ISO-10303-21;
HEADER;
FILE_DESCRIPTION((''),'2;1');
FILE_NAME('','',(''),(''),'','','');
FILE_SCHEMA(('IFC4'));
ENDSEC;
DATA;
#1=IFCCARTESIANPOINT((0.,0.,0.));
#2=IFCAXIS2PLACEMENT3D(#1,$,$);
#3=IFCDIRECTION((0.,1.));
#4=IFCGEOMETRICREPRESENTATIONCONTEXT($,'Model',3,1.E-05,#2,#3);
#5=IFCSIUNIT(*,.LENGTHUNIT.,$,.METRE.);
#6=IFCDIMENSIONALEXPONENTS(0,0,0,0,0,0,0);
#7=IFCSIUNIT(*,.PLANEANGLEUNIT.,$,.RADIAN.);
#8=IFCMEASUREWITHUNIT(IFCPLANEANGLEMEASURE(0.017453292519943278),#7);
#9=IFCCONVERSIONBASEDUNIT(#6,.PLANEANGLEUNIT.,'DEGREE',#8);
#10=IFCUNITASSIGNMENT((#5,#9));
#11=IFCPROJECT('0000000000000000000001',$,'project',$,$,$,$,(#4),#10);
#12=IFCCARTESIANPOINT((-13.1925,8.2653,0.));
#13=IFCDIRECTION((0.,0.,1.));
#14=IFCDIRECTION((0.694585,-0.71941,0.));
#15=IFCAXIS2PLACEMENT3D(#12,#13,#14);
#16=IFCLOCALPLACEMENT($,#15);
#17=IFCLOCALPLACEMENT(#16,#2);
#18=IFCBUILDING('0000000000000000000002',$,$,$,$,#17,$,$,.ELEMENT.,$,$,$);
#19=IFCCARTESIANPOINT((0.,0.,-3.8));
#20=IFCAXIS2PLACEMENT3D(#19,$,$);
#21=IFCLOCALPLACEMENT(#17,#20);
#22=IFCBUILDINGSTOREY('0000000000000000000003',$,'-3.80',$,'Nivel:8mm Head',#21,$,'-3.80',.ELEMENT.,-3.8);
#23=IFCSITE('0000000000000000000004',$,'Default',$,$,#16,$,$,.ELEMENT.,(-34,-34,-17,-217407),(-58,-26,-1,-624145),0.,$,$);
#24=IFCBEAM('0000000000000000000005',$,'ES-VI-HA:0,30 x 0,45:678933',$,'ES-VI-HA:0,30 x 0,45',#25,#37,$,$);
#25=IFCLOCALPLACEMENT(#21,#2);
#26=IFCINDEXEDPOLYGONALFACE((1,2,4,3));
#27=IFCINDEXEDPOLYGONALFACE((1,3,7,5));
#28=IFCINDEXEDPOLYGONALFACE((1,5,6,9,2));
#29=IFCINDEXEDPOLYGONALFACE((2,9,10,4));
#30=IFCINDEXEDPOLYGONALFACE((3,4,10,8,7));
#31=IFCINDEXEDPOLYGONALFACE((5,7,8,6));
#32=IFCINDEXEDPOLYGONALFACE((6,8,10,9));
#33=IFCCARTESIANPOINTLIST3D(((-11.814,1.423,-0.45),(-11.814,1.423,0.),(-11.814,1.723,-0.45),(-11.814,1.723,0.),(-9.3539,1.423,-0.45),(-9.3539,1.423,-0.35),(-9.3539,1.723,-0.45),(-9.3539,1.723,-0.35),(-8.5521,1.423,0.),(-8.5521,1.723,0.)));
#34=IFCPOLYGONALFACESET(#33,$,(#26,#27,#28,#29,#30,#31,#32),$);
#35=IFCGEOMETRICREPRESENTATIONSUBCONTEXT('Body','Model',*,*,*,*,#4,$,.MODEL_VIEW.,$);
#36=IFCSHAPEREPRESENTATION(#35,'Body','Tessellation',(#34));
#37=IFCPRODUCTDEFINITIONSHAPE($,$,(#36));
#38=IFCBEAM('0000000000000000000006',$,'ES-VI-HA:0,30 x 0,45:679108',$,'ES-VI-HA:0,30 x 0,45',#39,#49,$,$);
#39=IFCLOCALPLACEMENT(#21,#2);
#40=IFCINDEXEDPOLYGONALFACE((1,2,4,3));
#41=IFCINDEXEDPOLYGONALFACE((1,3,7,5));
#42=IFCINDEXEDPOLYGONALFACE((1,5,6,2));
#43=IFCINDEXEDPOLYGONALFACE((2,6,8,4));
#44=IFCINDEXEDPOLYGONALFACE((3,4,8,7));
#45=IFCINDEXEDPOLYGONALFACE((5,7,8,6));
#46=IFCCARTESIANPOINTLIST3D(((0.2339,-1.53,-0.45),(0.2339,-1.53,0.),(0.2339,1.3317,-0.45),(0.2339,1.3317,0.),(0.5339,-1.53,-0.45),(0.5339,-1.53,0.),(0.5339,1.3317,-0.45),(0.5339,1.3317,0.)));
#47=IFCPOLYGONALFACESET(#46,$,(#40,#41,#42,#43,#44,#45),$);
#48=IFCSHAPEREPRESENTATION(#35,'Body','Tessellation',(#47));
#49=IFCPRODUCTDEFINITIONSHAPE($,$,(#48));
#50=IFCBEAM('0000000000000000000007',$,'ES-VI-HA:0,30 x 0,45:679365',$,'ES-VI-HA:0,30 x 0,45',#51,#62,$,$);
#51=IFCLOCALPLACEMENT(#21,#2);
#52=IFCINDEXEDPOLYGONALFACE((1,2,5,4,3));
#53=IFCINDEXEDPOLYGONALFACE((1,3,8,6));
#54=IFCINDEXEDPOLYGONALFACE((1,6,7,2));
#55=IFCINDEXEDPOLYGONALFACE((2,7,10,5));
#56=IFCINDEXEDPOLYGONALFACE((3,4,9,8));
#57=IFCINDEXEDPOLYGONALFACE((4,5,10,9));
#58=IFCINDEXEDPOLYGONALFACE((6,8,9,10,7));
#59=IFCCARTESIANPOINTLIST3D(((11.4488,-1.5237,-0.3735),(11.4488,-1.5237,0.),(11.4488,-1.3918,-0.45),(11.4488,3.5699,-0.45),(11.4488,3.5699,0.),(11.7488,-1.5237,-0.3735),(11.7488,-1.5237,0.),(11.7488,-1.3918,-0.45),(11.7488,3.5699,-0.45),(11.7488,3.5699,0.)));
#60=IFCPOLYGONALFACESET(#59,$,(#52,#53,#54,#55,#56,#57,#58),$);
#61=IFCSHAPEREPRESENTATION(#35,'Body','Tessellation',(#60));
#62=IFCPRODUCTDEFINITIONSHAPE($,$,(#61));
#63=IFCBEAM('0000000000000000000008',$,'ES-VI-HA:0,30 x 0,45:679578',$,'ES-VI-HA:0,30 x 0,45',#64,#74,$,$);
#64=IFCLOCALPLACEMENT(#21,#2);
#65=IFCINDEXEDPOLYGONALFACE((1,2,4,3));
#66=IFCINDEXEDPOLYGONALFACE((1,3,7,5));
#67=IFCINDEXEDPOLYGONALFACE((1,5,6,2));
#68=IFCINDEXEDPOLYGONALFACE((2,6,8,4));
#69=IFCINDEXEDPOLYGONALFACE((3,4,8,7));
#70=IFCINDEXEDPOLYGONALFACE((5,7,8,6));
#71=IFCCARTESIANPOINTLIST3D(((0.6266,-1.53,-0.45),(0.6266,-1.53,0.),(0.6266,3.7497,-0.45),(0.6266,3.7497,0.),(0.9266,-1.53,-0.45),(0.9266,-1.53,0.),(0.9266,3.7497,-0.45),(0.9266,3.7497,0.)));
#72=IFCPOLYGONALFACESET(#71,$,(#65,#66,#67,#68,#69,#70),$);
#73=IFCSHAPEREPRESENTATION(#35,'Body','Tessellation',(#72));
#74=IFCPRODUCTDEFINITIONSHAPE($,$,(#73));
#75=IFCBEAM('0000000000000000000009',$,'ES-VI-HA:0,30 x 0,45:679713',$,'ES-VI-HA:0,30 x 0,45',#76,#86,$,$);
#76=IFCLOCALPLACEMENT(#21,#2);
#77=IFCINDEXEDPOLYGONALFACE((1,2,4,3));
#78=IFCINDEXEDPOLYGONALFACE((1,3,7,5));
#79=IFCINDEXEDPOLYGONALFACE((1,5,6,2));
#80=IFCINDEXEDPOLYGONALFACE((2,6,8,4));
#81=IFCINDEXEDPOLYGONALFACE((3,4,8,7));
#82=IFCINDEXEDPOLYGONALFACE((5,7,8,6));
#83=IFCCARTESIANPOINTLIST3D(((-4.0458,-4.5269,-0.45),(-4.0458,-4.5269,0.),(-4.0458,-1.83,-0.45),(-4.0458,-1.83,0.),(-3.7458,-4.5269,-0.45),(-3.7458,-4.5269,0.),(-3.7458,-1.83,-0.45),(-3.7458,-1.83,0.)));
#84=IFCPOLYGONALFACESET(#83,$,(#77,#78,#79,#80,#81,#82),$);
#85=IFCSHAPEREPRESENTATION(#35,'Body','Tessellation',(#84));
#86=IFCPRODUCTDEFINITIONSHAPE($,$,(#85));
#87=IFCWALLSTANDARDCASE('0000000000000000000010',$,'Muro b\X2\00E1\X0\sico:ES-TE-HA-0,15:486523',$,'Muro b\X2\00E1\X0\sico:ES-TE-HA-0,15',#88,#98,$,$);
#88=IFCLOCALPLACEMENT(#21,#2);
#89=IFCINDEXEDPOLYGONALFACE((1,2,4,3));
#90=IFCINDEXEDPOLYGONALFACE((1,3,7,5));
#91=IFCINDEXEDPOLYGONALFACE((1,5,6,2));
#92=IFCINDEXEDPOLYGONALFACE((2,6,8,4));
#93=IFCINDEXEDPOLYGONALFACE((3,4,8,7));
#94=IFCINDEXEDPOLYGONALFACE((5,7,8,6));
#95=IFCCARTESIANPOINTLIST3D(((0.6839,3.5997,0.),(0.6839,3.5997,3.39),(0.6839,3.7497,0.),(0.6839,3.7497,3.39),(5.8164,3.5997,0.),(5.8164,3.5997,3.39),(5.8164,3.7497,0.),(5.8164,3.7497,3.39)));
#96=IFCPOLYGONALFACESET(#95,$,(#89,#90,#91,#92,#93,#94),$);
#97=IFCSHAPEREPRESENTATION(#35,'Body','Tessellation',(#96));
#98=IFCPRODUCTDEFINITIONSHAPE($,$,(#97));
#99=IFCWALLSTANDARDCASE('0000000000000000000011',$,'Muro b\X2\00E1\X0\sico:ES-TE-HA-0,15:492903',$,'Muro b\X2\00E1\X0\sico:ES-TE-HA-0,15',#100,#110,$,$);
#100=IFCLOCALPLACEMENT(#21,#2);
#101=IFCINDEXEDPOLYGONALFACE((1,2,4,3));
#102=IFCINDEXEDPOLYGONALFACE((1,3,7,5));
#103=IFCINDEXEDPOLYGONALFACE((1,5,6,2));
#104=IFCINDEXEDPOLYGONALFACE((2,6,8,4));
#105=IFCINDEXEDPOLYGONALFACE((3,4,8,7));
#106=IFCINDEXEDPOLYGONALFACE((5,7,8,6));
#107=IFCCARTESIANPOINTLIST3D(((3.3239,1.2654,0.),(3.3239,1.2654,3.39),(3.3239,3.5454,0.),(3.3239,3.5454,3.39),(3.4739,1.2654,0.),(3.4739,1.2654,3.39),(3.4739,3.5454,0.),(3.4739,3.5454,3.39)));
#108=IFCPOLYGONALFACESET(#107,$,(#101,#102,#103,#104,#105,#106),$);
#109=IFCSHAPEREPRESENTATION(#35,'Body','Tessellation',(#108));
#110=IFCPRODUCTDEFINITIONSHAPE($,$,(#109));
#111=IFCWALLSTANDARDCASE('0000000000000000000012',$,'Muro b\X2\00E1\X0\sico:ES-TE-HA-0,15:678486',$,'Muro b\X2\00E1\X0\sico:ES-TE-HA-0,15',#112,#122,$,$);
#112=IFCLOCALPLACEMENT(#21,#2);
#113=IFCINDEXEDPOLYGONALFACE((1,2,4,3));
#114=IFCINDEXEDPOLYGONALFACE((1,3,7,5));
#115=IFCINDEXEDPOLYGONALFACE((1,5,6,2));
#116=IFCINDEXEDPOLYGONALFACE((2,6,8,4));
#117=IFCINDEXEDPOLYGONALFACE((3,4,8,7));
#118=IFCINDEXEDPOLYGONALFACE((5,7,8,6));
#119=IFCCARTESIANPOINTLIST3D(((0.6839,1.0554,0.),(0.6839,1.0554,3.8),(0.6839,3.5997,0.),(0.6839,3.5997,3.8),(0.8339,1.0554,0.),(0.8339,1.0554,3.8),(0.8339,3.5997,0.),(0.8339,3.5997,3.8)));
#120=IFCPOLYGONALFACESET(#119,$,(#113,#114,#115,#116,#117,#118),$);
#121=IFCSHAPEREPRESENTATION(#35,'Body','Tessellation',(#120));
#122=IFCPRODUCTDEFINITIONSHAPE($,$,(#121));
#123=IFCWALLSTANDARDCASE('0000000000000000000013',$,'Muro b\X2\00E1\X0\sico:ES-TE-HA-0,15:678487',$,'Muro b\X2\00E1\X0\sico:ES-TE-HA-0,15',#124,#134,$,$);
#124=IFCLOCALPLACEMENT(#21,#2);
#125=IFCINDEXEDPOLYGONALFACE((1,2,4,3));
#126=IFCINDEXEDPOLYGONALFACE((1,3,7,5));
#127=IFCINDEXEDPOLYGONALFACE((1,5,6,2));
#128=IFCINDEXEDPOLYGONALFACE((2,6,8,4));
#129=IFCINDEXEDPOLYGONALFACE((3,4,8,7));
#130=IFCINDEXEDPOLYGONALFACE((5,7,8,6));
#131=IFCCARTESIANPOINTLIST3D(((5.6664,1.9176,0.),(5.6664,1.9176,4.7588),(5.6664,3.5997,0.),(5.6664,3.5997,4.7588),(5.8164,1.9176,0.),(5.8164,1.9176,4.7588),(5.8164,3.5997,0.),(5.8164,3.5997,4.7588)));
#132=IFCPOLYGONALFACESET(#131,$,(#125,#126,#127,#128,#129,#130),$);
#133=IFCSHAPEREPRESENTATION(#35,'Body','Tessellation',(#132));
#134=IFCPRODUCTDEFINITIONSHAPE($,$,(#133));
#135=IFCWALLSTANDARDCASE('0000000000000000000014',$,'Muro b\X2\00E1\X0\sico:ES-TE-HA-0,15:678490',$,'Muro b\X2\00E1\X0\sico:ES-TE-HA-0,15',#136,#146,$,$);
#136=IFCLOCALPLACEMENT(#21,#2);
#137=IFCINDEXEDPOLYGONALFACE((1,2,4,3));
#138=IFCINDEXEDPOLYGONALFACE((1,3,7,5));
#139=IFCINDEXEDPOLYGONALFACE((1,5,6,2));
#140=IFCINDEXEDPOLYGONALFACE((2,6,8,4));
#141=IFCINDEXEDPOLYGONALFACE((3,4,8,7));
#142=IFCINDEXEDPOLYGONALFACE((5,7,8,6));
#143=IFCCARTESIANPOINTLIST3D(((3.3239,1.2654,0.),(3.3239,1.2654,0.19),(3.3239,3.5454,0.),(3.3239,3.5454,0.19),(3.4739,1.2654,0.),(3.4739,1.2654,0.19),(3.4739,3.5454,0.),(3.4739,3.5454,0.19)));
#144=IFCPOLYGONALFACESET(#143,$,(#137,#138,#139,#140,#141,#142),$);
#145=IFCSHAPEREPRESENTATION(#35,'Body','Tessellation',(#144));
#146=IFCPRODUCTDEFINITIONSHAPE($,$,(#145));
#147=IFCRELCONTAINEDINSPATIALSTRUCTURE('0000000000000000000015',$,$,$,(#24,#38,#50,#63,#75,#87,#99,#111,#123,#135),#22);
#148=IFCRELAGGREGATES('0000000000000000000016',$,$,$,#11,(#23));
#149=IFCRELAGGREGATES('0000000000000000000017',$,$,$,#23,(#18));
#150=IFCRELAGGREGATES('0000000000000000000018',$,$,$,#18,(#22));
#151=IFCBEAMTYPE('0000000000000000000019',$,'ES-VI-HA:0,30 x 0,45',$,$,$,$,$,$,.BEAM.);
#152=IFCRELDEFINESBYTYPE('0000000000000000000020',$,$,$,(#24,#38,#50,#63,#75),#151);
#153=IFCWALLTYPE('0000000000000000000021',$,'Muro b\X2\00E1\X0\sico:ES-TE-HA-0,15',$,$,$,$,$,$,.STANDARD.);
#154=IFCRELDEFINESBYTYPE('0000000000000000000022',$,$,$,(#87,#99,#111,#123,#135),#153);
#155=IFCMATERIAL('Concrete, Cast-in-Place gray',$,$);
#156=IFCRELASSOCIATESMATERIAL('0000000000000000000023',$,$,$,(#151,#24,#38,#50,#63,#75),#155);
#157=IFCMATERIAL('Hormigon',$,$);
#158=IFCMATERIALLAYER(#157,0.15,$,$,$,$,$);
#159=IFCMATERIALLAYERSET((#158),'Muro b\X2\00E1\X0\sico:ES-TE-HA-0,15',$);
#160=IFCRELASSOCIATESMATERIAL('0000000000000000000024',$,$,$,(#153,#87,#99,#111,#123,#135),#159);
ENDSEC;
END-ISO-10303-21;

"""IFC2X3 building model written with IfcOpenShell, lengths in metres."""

from ifc_helpers import new_model, entity, si_unit, converted_unit, direction, frame, frame_2d, origin, origin_2d_with_axis, place, context, subcontext, project, spatial, polyline, rectangle, extrude, clip, halfspace, bounded_halfspace, material, layer, layer_set, layer_usage, type_object, element, save


model = new_model("IFC2X3")

# Units and contexts
model_context = context("Model", 3, precision=1e-05, world=origin(), true_north=direction((0.0, 1.0)))
body_context = subcontext(model_context, "Body", "Model", "MODEL_VIEW")
ifc_project = project(units=[si_unit("LENGTHUNIT", "METRE"), converted_unit("PLANEANGLEUNIT", "DEGREE", entity("IfcPlaneAngleMeasure", 0.017453292519943278), si_unit("PLANEANGLEUNIT", "RADIAN"), dimensions=[0, 0, 0, 0, 0, 0, 0])], contexts=[model_context])

# Site, building, storey
site_placement = place(None, frame((-13.1925, 8.2653, 0.0), z_axis=(0.0, 0.0, 1.0), x_axis=(0.694585, -0.71941, 0.0)))
site = spatial("IfcSite", under=ifc_project, at=site_placement, Name="Default", CompositionType="ELEMENT", RefLatitude=(-34, -34, -17, -217407), RefLongitude=(-58, -26, -1, -624145), RefElevation=0.0)
building_placement = place(site_placement, origin())
building = spatial("IfcBuilding", under=site, at=building_placement, CompositionType="ELEMENT")
storey_placement = place(building_placement, frame((0.0, 0.0, -3.8)))
storey = spatial("IfcBuildingStorey", under=building, at=storey_placement, Name="-3.80", ObjectType="Nivel:8mm Head", LongName="-3.80", CompositionType="ELEMENT", Elevation=-3.8)

# Beams
ifc_material_1 = material(Name="Concrete, Cast-in-Place gray")
beam_type_1 = type_object("IfcBeamType", Name="ES-VI-HA:0,30 x 0,45", PredefinedType="BEAM", material=ifc_material_1)
beam_1_placement = place(storey_placement, frame((-11.814, 1.573, 0.0)))
element("IfcBeam", 1, at=beam_1_placement, inside=storey, type_object=beam_type_1, material=ifc_material_1, Name="ES-VI-HA:0,30 x 0,45:678933", ObjectType="ES-VI-HA:0,30 x 0,45", context=body_context, shape_type="SweptSolid", body=[
    clip(clip(extrude(rectangle(XDim=0.45, YDim=0.3, at=frame_2d((0.0, 0.0), x_axis=(0.0, 1.0))), frame((0.0, 0.0, -0.225), z_axis=(1.0, 0.0, 0.0), x_axis=(0.0, 1.0, 0.0)), (0.0, 0.0, 1.0), 3.2619), bounded_halfspace(frame((2.4601, 0.0748, -0.35), z_axis=(0.400079, 0.0, -0.916481), x_axis=(0.0, -1.0, 0.0)), False, frame((0.0, 0.0, -0.225), z_axis=(1.0, 0.0, 0.0), x_axis=(0.0, 1.0, 0.0)), polyline([(-0.15, -0.125), (0.15, -0.125), (0.15, 0.225), (-0.15, 0.225), (-0.15, -0.125)]))), bounded_halfspace(frame((2.4601, 1.0248, -0.35), z_axis=(1.0, 0.0, 0.0), x_axis=(0.0, 0.0, -1.0)), False, frame((0.0, 0.0, -0.225), z_axis=(1.0, 0.0, 0.0), x_axis=(0.0, 1.0, 0.0)), polyline([(0.15, -0.125), (-0.15, -0.125), (-0.15, -0.225), (0.15, -0.225), (0.15, -0.125)]))),
])
beam_2_placement = place(storey_placement, frame((0.3839, -1.68, 0.0), z_axis=(0.0, 0.0, 1.0), x_axis=(0.0, 1.0, 0.0)))
element("IfcBeam", 2, at=beam_2_placement, inside=storey, type_object=beam_type_1, material=ifc_material_1, Name="ES-VI-HA:0,30 x 0,45:679108", ObjectType="ES-VI-HA:0,30 x 0,45", context=body_context, shape_type="SweptSolid", body=[
    extrude(rectangle(XDim=0.45, YDim=0.3, at=frame_2d((0.0, 0.0), x_axis=(1.0, 0.0))), frame((0.15, 0.0, -0.225), z_axis=(1.0, 0.0, 0.0), x_axis=(0.0, 0.0, -1.0)), (0.0, 0.0, 1.0), 2.8617),
])
beam_3_placement = place(storey_placement, frame((11.5988, -1.5237, 0.0), z_axis=(0.0, 0.0, 1.0), x_axis=(0.0, 1.0, 0.0)))
element("IfcBeam", 3, at=beam_3_placement, inside=storey, type_object=beam_type_1, material=ifc_material_1, Name="ES-VI-HA:0,30 x 0,45:679365", ObjectType="ES-VI-HA:0,30 x 0,45", context=body_context, shape_type="SweptSolid", body=[
    clip(extrude(rectangle(XDim=0.45, YDim=0.3, at=frame_2d((0.0, 0.0), x_axis=(0.0, 1.0))), frame((0.0, 0.0, -0.225), z_axis=(1.0, 0.0, 0.0), x_axis=(0.0, 1.0, 0.0)), (0.0, 0.0, 1.0), 5.0936), halfspace(frame((0.9944, 0.0, -0.95), z_axis=(-0.50153, 0.0, -0.86514), x_axis=(0.0, 1.0, 0.0)), False)),
])
beam_4_placement = place(storey_placement, frame((0.7766, -1.68, 0.0), z_axis=(0.0, 0.0, 1.0), x_axis=(0.0, 1.0, 0.0)))
element("IfcBeam", 4, at=beam_4_placement, inside=storey, type_object=beam_type_1, material=ifc_material_1, Name="ES-VI-HA:0,30 x 0,45:679578", ObjectType="ES-VI-HA:0,30 x 0,45", context=body_context, shape_type="SweptSolid", body=[
    extrude(rectangle(XDim=0.45, YDim=0.3, at=origin_2d_with_axis()), frame((0.15, 0.0, -0.225), z_axis=(1.0, 0.0, 0.0), x_axis=(0.0, 0.0, -1.0)), (0.0, 0.0, 1.0), 5.2797),
])
beam_5_placement = place(storey_placement, frame((-3.8958, -4.5269, 0.0), z_axis=(0.0, 0.0, 1.0), x_axis=(0.0, 1.0, 0.0)))
element("IfcBeam", 5, at=beam_5_placement, inside=storey, type_object=beam_type_1, material=ifc_material_1, Name="ES-VI-HA:0,30 x 0,45:679713", ObjectType="ES-VI-HA:0,30 x 0,45", context=body_context, shape_type="SweptSolid", body=[
    extrude(rectangle(XDim=0.45, YDim=0.3, at=frame_2d((0.0, 0.0), x_axis=(1.0, 0.0))), frame((0.0, 0.0, -0.225), z_axis=(1.0, 0.0, 0.0), x_axis=(0.0, 0.0, -1.0)), (0.0, 0.0, 1.0), 2.6969),
])

# Walls
ifc_material_2 = material(Name="Hormigon")
ifc_layer = layer(ifc_material_2, 0.15)
ifc_layer_set = layer_set([ifc_layer], Name="Muro básico:ES-TE-HA-0,15")
ifc_layer_usage_1 = layer_usage(ifc_layer_set, "AXIS2", "NEGATIVE", 0.075)
wall_type = type_object("IfcWallType", Name="Muro básico:ES-TE-HA-0,15", PredefinedType="STANDARD", material=ifc_layer_set)
wall_1_placement = place(storey_placement, frame((0.6839, 3.6747, 0.0)))
element("IfcWallStandardCase", 6, at=wall_1_placement, inside=storey, type_object=wall_type, material=ifc_layer_usage_1, Name="Muro básico:ES-TE-HA-0,15:486523", ObjectType="Muro básico:ES-TE-HA-0,15", context=body_context, shape_type="SweptSolid", body=[
    extrude(rectangle(XDim=5.1325, YDim=0.15, at=frame_2d((2.5662, 0.0), x_axis=(-1.0, 0.0))), origin(), (0.0, 0.0, 1.0), 3.39),
])
ifc_layer_usage_2 = layer_usage(ifc_layer_set, "AXIS2", "NEGATIVE", 0.075)
wall_2_placement = place(storey_placement, frame((3.3989, 1.2654, 0.0), z_axis=(0.0, 0.0, 1.0), x_axis=(0.0, 1.0, 0.0)))
element("IfcWallStandardCase", 7, at=wall_2_placement, inside=storey, type_object=wall_type, material=ifc_layer_usage_2, Name="Muro básico:ES-TE-HA-0,15:492903", ObjectType="Muro básico:ES-TE-HA-0,15", context=body_context, shape_type="SweptSolid", body=[
    extrude(rectangle(XDim=2.2801, YDim=0.15, at=frame_2d((1.14, 0.0), x_axis=(-1.0, 0.0))), origin(), (0.0, 0.0, 1.0), 3.39),
])
ifc_layer_usage_3 = layer_usage(ifc_layer_set, "AXIS2", "NEGATIVE", 0.075)
wall_3_placement = place(storey_placement, frame((0.7589, 1.0554, 0.0), z_axis=(0.0, 0.0, 1.0), x_axis=(0.0, 1.0, 0.0)))
element("IfcWallStandardCase", 8, at=wall_3_placement, inside=storey, type_object=wall_type, material=ifc_layer_usage_3, Name="Muro básico:ES-TE-HA-0,15:678486", ObjectType="Muro básico:ES-TE-HA-0,15", context=body_context, shape_type="SweptSolid", body=[
    extrude(rectangle(XDim=2.5442, YDim=0.15, at=frame_2d((1.2721, 0.0), x_axis=(-1.0, 0.0))), origin(), (0.0, 0.0, 1.0), 3.8),
])
ifc_layer_usage_4 = layer_usage(ifc_layer_set, "AXIS2", "NEGATIVE", 0.075)
wall_4_placement = place(storey_placement, frame((5.7414, 1.9176, 0.0), z_axis=(0.0, 0.0, 1.0), x_axis=(0.0, 1.0, 0.0)))
element("IfcWallStandardCase", 9, at=wall_4_placement, inside=storey, type_object=wall_type, material=ifc_layer_usage_4, Name="Muro básico:ES-TE-HA-0,15:678487", ObjectType="Muro básico:ES-TE-HA-0,15", context=body_context, shape_type="SweptSolid", body=[
    extrude(rectangle(XDim=1.682, YDim=0.15, at=frame_2d((0.841, 0.0), x_axis=(-1.0, 0.0))), origin(), (0.0, 0.0, 1.0), 4.7588),
])
ifc_layer_usage_5 = layer_usage(ifc_layer_set, "AXIS2", "NEGATIVE", 0.075)
wall_5_placement = place(storey_placement, frame((3.3989, 1.2654, 0.0), z_axis=(0.0, 0.0, 1.0), x_axis=(0.0, 1.0, 0.0)))
element("IfcWallStandardCase", 10, at=wall_5_placement, inside=storey, type_object=wall_type, material=ifc_layer_usage_5, Name="Muro básico:ES-TE-HA-0,15:678490", ObjectType="Muro básico:ES-TE-HA-0,15", context=body_context, shape_type="SweptSolid", body=[
    extrude(rectangle(XDim=2.2801, YDim=0.15, at=frame_2d((1.14, 0.0), x_axis=(-1.0, 0.0))), origin(), (0.0, 0.0, 1.0), 0.19),
])

save(model, "model.ifc")
